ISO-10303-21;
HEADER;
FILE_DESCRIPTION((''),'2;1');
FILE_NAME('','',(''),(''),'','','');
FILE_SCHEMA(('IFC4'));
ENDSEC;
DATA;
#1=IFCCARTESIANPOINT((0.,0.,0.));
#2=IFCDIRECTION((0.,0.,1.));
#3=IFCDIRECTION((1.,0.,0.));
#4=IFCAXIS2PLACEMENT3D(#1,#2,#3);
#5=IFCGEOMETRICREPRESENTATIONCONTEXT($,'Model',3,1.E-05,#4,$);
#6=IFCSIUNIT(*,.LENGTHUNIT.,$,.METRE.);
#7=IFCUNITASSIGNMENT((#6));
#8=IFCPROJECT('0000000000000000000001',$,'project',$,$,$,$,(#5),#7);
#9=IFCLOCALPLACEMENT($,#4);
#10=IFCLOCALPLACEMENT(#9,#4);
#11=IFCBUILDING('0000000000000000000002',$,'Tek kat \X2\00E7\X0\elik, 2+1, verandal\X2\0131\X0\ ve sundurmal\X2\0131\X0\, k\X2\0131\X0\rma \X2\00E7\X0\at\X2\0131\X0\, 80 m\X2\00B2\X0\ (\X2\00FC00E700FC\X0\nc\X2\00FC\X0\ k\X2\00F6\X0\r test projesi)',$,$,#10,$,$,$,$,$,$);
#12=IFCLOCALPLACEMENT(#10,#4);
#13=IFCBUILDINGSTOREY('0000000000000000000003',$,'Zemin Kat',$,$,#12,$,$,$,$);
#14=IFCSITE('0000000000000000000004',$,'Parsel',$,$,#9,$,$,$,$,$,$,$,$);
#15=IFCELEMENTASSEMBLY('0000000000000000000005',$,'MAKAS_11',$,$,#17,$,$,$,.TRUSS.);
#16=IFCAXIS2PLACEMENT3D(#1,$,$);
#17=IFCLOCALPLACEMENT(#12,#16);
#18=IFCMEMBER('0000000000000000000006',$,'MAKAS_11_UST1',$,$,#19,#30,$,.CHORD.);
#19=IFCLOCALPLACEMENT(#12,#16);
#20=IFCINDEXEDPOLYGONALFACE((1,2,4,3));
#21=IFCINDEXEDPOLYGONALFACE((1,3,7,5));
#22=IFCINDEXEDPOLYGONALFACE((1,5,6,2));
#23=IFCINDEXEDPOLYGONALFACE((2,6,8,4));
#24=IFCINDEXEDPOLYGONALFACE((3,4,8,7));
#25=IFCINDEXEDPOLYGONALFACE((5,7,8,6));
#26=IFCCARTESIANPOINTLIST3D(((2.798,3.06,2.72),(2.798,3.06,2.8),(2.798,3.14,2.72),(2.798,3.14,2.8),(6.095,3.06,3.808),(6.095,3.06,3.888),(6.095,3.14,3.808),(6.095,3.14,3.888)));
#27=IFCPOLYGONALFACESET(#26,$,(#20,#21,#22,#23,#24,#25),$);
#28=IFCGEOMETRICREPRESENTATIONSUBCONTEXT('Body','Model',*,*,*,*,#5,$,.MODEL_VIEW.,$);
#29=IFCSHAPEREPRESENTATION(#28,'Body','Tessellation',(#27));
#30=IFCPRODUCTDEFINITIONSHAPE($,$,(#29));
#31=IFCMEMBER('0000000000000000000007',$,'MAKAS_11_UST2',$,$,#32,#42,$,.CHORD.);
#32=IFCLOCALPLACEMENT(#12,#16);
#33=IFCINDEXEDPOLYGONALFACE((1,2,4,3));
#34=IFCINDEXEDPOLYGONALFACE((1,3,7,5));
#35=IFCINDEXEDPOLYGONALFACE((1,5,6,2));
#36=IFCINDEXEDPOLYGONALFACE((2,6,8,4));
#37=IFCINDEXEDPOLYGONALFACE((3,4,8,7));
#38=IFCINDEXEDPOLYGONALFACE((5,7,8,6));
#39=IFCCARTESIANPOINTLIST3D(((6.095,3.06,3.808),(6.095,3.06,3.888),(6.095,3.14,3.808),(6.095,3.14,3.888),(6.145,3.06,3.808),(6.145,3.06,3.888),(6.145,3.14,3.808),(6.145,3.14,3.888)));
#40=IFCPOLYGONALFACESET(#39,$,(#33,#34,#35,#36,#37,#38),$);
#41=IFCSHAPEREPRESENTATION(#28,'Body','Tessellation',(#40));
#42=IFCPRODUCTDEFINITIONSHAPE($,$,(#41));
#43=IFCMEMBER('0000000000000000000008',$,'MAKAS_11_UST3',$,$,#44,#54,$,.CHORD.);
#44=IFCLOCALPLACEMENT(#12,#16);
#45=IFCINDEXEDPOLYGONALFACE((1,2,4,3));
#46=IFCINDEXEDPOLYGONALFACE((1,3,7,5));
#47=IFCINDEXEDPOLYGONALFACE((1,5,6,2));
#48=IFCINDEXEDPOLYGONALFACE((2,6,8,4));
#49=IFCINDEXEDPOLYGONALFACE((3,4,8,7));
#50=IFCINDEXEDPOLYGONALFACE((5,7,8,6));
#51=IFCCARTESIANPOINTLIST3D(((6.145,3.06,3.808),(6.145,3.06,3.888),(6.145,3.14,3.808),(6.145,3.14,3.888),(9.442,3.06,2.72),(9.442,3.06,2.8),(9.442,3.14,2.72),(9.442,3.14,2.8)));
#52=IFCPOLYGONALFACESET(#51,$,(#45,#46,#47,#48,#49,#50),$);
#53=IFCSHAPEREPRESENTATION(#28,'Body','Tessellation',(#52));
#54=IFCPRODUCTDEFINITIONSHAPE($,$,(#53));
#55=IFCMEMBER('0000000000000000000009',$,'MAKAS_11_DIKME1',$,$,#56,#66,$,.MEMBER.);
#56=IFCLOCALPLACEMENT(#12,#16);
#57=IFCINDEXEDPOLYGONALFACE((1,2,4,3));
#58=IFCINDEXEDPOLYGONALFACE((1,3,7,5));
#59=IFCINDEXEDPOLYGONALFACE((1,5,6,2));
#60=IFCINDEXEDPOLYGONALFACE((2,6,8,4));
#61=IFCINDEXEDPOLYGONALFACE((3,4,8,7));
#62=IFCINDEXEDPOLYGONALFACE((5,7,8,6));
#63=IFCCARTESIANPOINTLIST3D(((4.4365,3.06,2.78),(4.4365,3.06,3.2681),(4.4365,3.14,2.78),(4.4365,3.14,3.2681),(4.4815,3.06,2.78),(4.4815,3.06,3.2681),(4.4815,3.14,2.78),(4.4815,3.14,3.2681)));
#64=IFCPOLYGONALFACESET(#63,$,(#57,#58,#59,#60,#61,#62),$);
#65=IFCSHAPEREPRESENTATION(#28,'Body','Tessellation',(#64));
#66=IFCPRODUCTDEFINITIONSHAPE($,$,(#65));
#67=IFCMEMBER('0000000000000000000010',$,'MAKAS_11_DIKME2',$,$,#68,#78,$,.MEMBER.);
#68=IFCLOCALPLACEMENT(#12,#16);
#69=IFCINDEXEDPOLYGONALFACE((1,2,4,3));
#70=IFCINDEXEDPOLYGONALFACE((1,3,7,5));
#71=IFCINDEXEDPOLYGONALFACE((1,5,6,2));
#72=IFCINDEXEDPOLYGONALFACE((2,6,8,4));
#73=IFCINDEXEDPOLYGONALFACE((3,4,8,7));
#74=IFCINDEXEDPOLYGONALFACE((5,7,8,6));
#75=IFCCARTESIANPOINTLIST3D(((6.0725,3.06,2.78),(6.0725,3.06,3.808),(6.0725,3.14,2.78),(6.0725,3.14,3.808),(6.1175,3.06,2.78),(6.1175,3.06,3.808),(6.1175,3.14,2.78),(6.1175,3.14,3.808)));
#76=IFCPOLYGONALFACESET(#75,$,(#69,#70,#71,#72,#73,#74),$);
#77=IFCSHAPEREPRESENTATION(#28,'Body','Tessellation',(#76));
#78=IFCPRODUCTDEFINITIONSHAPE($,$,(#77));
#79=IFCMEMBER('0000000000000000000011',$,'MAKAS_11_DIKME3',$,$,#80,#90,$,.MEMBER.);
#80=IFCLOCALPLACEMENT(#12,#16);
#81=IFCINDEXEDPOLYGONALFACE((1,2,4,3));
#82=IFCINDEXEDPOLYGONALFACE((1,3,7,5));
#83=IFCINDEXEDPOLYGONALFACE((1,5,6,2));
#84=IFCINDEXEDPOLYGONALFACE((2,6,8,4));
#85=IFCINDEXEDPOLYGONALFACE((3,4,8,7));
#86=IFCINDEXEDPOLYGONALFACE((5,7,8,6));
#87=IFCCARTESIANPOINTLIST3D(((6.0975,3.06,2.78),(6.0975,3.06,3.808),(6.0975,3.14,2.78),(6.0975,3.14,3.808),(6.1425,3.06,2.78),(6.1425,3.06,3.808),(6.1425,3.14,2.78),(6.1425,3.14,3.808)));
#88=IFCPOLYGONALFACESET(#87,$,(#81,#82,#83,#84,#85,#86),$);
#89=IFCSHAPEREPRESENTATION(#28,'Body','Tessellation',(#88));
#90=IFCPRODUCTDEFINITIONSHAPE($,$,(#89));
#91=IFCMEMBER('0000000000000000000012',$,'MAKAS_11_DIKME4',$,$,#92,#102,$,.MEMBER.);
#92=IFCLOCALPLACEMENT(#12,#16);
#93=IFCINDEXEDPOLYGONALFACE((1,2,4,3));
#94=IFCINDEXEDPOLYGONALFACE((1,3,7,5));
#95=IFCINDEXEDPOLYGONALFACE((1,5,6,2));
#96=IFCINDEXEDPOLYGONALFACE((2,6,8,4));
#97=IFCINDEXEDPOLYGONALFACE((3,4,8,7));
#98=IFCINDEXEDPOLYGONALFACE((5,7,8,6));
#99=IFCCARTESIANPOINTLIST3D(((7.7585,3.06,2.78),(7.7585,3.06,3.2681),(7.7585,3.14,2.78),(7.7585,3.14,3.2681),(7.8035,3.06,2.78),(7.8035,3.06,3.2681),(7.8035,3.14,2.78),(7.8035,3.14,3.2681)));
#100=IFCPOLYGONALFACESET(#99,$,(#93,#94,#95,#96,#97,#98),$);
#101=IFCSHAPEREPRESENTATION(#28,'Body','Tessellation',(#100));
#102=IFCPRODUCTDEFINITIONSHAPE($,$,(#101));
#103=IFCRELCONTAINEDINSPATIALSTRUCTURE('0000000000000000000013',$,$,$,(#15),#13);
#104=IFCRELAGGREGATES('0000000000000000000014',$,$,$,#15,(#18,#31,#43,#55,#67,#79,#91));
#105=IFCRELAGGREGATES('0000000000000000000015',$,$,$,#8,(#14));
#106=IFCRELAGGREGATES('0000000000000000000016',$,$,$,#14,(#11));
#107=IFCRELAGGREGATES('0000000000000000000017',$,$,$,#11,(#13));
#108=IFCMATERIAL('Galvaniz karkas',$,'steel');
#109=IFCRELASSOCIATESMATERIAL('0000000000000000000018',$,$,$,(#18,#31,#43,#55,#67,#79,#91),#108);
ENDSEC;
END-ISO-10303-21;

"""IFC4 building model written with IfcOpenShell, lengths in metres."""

from ifc_helpers import new_model, si_unit, frame, origin_with_axes, place, context, subcontext, project, spatial, line, indexed_curve, outline, extrude, material, element, aggregate, save


model = new_model("IFC4")

# Units and contexts
model_context = context("Model", 3, precision=1e-05, world=origin_with_axes())
body_context = subcontext(model_context, "Body", "Model", "MODEL_VIEW")
ifc_project = project(units=[si_unit("LENGTHUNIT", "METRE")], contexts=[model_context])

# Site, building, storey
site_placement = place(None, origin_with_axes())
site = spatial("IfcSite", under=ifc_project, at=site_placement, Name="Parsel")
building_placement = place(site_placement, origin_with_axes())
building = spatial("IfcBuilding", under=site, at=building_placement, Name="Tek kat çelik, 2+1, verandalı ve sundurmalı, kırma çatı, 80 m² (üçüncü kör test projesi)")
storey_placement = place(building_placement, origin_with_axes())
storey = spatial("IfcBuildingStorey", under=building, at=storey_placement, Name="Zemin Kat")

# Element assembly, members
ifc_material = material(Name="Galvaniz karkas", Category="steel")
assembly_1_placement = place(storey_placement, origin_with_axes())
assembly_1 = element("IfcElementAssembly", 1, at=assembly_1_placement, inside=storey, Name="MAKAS_11", PredefinedType="TRUSS")
member_1_placement = place(assembly_1_placement, origin_with_axes())
member_1 = element("IfcMember", 2, at=member_1_placement, material=ifc_material, Name="MAKAS_11_UST1", PredefinedType="CHORD", context=body_context, shape_type="SweptSolid", body=[
    extrude(outline(indexed_curve([(2.798, 2.72), (6.095, 3.808), (6.095, 3.888), (2.798, 2.8)], segments=[line(1, 2, 3, 4, 1)])), frame((0.0, 3.14, 0.0), z_axis=(0.0, -1.0, 0.0), x_axis=(1.0, 0.0, 0.0)), (0.0, 0.0, 1.0), 0.08),
])
member_2_placement = place(assembly_1_placement, origin_with_axes())
member_2 = element("IfcMember", 3, at=member_2_placement, material=ifc_material, Name="MAKAS_11_UST2", PredefinedType="CHORD", context=body_context, shape_type="SweptSolid", body=[
    extrude(outline(indexed_curve([(6.095, 3.808), (6.145, 3.808), (6.145, 3.888), (6.095, 3.888)], segments=[line(1, 2, 3, 4, 1)])), frame((0.0, 3.14, 0.0), z_axis=(0.0, -1.0, 0.0), x_axis=(1.0, 0.0, 0.0)), (0.0, 0.0, 1.0), 0.08),
])
member_3_placement = place(assembly_1_placement, origin_with_axes())
member_3 = element("IfcMember", 4, at=member_3_placement, material=ifc_material, Name="MAKAS_11_UST3", PredefinedType="CHORD", context=body_context, shape_type="SweptSolid", body=[
    extrude(outline(indexed_curve([(6.145, 3.808), (9.442, 2.72), (9.442, 2.8), (6.145, 3.888)], segments=[line(1, 2, 3, 4, 1)])), frame((0.0, 3.14, 0.0), z_axis=(0.0, -1.0, 0.0), x_axis=(1.0, 0.0, 0.0)), (0.0, 0.0, 1.0), 0.08),
])
member_4_placement = place(assembly_1_placement, origin_with_axes())
member_4 = element("IfcMember", 5, at=member_4_placement, material=ifc_material, Name="MAKAS_11_DIKME1", PredefinedType="MEMBER", context=body_context, shape_type="SweptSolid", body=[
    extrude(outline(indexed_curve([(4.4365, 2.78), (4.4815, 2.78), (4.4815, 3.2681), (4.4365, 3.2681)], segments=[line(1, 2, 3, 4, 1)])), frame((0.0, 3.14, 0.0), z_axis=(0.0, -1.0, 0.0), x_axis=(1.0, 0.0, 0.0)), (0.0, 0.0, 1.0), 0.08),
])
member_5_placement = place(assembly_1_placement, origin_with_axes())
member_5 = element("IfcMember", 6, at=member_5_placement, material=ifc_material, Name="MAKAS_11_DIKME2", PredefinedType="MEMBER", context=body_context, shape_type="SweptSolid", body=[
    extrude(outline(indexed_curve([(6.0725, 2.78), (6.1175, 2.78), (6.1175, 3.808), (6.0725, 3.808)], segments=[line(1, 2, 3, 4, 1)])), frame((0.0, 3.14, 0.0), z_axis=(0.0, -1.0, 0.0), x_axis=(1.0, 0.0, 0.0)), (0.0, 0.0, 1.0), 0.08),
])
member_6_placement = place(assembly_1_placement, origin_with_axes())
member_6 = element("IfcMember", 7, at=member_6_placement, material=ifc_material, Name="MAKAS_11_DIKME3", PredefinedType="MEMBER", context=body_context, shape_type="SweptSolid", body=[
    extrude(outline(indexed_curve([(6.0975, 2.78), (6.1425, 2.78), (6.1425, 3.808), (6.0975, 3.808)], segments=[line(1, 2, 3, 4, 1)])), frame((0.0, 3.14, 0.0), z_axis=(0.0, -1.0, 0.0), x_axis=(1.0, 0.0, 0.0)), (0.0, 0.0, 1.0), 0.08),
])
member_7_placement = place(assembly_1_placement, origin_with_axes())
member_7 = element("IfcMember", 8, at=member_7_placement, material=ifc_material, Name="MAKAS_11_DIKME4", PredefinedType="MEMBER", context=body_context, shape_type="SweptSolid", body=[
    extrude(outline(indexed_curve([(7.7585, 2.78), (7.8035, 2.78), (7.8035, 3.2681), (7.7585, 3.2681)], segments=[line(1, 2, 3, 4, 1)])), frame((0.0, 3.14, 0.0), z_axis=(0.0, -1.0, 0.0), x_axis=(1.0, 0.0, 0.0)), (0.0, 0.0, 1.0), 0.08),
])
aggregate(assembly_1, [member_1, member_2, member_3, member_4, member_5, member_6, member_7])

save(model, "model.ifc")
